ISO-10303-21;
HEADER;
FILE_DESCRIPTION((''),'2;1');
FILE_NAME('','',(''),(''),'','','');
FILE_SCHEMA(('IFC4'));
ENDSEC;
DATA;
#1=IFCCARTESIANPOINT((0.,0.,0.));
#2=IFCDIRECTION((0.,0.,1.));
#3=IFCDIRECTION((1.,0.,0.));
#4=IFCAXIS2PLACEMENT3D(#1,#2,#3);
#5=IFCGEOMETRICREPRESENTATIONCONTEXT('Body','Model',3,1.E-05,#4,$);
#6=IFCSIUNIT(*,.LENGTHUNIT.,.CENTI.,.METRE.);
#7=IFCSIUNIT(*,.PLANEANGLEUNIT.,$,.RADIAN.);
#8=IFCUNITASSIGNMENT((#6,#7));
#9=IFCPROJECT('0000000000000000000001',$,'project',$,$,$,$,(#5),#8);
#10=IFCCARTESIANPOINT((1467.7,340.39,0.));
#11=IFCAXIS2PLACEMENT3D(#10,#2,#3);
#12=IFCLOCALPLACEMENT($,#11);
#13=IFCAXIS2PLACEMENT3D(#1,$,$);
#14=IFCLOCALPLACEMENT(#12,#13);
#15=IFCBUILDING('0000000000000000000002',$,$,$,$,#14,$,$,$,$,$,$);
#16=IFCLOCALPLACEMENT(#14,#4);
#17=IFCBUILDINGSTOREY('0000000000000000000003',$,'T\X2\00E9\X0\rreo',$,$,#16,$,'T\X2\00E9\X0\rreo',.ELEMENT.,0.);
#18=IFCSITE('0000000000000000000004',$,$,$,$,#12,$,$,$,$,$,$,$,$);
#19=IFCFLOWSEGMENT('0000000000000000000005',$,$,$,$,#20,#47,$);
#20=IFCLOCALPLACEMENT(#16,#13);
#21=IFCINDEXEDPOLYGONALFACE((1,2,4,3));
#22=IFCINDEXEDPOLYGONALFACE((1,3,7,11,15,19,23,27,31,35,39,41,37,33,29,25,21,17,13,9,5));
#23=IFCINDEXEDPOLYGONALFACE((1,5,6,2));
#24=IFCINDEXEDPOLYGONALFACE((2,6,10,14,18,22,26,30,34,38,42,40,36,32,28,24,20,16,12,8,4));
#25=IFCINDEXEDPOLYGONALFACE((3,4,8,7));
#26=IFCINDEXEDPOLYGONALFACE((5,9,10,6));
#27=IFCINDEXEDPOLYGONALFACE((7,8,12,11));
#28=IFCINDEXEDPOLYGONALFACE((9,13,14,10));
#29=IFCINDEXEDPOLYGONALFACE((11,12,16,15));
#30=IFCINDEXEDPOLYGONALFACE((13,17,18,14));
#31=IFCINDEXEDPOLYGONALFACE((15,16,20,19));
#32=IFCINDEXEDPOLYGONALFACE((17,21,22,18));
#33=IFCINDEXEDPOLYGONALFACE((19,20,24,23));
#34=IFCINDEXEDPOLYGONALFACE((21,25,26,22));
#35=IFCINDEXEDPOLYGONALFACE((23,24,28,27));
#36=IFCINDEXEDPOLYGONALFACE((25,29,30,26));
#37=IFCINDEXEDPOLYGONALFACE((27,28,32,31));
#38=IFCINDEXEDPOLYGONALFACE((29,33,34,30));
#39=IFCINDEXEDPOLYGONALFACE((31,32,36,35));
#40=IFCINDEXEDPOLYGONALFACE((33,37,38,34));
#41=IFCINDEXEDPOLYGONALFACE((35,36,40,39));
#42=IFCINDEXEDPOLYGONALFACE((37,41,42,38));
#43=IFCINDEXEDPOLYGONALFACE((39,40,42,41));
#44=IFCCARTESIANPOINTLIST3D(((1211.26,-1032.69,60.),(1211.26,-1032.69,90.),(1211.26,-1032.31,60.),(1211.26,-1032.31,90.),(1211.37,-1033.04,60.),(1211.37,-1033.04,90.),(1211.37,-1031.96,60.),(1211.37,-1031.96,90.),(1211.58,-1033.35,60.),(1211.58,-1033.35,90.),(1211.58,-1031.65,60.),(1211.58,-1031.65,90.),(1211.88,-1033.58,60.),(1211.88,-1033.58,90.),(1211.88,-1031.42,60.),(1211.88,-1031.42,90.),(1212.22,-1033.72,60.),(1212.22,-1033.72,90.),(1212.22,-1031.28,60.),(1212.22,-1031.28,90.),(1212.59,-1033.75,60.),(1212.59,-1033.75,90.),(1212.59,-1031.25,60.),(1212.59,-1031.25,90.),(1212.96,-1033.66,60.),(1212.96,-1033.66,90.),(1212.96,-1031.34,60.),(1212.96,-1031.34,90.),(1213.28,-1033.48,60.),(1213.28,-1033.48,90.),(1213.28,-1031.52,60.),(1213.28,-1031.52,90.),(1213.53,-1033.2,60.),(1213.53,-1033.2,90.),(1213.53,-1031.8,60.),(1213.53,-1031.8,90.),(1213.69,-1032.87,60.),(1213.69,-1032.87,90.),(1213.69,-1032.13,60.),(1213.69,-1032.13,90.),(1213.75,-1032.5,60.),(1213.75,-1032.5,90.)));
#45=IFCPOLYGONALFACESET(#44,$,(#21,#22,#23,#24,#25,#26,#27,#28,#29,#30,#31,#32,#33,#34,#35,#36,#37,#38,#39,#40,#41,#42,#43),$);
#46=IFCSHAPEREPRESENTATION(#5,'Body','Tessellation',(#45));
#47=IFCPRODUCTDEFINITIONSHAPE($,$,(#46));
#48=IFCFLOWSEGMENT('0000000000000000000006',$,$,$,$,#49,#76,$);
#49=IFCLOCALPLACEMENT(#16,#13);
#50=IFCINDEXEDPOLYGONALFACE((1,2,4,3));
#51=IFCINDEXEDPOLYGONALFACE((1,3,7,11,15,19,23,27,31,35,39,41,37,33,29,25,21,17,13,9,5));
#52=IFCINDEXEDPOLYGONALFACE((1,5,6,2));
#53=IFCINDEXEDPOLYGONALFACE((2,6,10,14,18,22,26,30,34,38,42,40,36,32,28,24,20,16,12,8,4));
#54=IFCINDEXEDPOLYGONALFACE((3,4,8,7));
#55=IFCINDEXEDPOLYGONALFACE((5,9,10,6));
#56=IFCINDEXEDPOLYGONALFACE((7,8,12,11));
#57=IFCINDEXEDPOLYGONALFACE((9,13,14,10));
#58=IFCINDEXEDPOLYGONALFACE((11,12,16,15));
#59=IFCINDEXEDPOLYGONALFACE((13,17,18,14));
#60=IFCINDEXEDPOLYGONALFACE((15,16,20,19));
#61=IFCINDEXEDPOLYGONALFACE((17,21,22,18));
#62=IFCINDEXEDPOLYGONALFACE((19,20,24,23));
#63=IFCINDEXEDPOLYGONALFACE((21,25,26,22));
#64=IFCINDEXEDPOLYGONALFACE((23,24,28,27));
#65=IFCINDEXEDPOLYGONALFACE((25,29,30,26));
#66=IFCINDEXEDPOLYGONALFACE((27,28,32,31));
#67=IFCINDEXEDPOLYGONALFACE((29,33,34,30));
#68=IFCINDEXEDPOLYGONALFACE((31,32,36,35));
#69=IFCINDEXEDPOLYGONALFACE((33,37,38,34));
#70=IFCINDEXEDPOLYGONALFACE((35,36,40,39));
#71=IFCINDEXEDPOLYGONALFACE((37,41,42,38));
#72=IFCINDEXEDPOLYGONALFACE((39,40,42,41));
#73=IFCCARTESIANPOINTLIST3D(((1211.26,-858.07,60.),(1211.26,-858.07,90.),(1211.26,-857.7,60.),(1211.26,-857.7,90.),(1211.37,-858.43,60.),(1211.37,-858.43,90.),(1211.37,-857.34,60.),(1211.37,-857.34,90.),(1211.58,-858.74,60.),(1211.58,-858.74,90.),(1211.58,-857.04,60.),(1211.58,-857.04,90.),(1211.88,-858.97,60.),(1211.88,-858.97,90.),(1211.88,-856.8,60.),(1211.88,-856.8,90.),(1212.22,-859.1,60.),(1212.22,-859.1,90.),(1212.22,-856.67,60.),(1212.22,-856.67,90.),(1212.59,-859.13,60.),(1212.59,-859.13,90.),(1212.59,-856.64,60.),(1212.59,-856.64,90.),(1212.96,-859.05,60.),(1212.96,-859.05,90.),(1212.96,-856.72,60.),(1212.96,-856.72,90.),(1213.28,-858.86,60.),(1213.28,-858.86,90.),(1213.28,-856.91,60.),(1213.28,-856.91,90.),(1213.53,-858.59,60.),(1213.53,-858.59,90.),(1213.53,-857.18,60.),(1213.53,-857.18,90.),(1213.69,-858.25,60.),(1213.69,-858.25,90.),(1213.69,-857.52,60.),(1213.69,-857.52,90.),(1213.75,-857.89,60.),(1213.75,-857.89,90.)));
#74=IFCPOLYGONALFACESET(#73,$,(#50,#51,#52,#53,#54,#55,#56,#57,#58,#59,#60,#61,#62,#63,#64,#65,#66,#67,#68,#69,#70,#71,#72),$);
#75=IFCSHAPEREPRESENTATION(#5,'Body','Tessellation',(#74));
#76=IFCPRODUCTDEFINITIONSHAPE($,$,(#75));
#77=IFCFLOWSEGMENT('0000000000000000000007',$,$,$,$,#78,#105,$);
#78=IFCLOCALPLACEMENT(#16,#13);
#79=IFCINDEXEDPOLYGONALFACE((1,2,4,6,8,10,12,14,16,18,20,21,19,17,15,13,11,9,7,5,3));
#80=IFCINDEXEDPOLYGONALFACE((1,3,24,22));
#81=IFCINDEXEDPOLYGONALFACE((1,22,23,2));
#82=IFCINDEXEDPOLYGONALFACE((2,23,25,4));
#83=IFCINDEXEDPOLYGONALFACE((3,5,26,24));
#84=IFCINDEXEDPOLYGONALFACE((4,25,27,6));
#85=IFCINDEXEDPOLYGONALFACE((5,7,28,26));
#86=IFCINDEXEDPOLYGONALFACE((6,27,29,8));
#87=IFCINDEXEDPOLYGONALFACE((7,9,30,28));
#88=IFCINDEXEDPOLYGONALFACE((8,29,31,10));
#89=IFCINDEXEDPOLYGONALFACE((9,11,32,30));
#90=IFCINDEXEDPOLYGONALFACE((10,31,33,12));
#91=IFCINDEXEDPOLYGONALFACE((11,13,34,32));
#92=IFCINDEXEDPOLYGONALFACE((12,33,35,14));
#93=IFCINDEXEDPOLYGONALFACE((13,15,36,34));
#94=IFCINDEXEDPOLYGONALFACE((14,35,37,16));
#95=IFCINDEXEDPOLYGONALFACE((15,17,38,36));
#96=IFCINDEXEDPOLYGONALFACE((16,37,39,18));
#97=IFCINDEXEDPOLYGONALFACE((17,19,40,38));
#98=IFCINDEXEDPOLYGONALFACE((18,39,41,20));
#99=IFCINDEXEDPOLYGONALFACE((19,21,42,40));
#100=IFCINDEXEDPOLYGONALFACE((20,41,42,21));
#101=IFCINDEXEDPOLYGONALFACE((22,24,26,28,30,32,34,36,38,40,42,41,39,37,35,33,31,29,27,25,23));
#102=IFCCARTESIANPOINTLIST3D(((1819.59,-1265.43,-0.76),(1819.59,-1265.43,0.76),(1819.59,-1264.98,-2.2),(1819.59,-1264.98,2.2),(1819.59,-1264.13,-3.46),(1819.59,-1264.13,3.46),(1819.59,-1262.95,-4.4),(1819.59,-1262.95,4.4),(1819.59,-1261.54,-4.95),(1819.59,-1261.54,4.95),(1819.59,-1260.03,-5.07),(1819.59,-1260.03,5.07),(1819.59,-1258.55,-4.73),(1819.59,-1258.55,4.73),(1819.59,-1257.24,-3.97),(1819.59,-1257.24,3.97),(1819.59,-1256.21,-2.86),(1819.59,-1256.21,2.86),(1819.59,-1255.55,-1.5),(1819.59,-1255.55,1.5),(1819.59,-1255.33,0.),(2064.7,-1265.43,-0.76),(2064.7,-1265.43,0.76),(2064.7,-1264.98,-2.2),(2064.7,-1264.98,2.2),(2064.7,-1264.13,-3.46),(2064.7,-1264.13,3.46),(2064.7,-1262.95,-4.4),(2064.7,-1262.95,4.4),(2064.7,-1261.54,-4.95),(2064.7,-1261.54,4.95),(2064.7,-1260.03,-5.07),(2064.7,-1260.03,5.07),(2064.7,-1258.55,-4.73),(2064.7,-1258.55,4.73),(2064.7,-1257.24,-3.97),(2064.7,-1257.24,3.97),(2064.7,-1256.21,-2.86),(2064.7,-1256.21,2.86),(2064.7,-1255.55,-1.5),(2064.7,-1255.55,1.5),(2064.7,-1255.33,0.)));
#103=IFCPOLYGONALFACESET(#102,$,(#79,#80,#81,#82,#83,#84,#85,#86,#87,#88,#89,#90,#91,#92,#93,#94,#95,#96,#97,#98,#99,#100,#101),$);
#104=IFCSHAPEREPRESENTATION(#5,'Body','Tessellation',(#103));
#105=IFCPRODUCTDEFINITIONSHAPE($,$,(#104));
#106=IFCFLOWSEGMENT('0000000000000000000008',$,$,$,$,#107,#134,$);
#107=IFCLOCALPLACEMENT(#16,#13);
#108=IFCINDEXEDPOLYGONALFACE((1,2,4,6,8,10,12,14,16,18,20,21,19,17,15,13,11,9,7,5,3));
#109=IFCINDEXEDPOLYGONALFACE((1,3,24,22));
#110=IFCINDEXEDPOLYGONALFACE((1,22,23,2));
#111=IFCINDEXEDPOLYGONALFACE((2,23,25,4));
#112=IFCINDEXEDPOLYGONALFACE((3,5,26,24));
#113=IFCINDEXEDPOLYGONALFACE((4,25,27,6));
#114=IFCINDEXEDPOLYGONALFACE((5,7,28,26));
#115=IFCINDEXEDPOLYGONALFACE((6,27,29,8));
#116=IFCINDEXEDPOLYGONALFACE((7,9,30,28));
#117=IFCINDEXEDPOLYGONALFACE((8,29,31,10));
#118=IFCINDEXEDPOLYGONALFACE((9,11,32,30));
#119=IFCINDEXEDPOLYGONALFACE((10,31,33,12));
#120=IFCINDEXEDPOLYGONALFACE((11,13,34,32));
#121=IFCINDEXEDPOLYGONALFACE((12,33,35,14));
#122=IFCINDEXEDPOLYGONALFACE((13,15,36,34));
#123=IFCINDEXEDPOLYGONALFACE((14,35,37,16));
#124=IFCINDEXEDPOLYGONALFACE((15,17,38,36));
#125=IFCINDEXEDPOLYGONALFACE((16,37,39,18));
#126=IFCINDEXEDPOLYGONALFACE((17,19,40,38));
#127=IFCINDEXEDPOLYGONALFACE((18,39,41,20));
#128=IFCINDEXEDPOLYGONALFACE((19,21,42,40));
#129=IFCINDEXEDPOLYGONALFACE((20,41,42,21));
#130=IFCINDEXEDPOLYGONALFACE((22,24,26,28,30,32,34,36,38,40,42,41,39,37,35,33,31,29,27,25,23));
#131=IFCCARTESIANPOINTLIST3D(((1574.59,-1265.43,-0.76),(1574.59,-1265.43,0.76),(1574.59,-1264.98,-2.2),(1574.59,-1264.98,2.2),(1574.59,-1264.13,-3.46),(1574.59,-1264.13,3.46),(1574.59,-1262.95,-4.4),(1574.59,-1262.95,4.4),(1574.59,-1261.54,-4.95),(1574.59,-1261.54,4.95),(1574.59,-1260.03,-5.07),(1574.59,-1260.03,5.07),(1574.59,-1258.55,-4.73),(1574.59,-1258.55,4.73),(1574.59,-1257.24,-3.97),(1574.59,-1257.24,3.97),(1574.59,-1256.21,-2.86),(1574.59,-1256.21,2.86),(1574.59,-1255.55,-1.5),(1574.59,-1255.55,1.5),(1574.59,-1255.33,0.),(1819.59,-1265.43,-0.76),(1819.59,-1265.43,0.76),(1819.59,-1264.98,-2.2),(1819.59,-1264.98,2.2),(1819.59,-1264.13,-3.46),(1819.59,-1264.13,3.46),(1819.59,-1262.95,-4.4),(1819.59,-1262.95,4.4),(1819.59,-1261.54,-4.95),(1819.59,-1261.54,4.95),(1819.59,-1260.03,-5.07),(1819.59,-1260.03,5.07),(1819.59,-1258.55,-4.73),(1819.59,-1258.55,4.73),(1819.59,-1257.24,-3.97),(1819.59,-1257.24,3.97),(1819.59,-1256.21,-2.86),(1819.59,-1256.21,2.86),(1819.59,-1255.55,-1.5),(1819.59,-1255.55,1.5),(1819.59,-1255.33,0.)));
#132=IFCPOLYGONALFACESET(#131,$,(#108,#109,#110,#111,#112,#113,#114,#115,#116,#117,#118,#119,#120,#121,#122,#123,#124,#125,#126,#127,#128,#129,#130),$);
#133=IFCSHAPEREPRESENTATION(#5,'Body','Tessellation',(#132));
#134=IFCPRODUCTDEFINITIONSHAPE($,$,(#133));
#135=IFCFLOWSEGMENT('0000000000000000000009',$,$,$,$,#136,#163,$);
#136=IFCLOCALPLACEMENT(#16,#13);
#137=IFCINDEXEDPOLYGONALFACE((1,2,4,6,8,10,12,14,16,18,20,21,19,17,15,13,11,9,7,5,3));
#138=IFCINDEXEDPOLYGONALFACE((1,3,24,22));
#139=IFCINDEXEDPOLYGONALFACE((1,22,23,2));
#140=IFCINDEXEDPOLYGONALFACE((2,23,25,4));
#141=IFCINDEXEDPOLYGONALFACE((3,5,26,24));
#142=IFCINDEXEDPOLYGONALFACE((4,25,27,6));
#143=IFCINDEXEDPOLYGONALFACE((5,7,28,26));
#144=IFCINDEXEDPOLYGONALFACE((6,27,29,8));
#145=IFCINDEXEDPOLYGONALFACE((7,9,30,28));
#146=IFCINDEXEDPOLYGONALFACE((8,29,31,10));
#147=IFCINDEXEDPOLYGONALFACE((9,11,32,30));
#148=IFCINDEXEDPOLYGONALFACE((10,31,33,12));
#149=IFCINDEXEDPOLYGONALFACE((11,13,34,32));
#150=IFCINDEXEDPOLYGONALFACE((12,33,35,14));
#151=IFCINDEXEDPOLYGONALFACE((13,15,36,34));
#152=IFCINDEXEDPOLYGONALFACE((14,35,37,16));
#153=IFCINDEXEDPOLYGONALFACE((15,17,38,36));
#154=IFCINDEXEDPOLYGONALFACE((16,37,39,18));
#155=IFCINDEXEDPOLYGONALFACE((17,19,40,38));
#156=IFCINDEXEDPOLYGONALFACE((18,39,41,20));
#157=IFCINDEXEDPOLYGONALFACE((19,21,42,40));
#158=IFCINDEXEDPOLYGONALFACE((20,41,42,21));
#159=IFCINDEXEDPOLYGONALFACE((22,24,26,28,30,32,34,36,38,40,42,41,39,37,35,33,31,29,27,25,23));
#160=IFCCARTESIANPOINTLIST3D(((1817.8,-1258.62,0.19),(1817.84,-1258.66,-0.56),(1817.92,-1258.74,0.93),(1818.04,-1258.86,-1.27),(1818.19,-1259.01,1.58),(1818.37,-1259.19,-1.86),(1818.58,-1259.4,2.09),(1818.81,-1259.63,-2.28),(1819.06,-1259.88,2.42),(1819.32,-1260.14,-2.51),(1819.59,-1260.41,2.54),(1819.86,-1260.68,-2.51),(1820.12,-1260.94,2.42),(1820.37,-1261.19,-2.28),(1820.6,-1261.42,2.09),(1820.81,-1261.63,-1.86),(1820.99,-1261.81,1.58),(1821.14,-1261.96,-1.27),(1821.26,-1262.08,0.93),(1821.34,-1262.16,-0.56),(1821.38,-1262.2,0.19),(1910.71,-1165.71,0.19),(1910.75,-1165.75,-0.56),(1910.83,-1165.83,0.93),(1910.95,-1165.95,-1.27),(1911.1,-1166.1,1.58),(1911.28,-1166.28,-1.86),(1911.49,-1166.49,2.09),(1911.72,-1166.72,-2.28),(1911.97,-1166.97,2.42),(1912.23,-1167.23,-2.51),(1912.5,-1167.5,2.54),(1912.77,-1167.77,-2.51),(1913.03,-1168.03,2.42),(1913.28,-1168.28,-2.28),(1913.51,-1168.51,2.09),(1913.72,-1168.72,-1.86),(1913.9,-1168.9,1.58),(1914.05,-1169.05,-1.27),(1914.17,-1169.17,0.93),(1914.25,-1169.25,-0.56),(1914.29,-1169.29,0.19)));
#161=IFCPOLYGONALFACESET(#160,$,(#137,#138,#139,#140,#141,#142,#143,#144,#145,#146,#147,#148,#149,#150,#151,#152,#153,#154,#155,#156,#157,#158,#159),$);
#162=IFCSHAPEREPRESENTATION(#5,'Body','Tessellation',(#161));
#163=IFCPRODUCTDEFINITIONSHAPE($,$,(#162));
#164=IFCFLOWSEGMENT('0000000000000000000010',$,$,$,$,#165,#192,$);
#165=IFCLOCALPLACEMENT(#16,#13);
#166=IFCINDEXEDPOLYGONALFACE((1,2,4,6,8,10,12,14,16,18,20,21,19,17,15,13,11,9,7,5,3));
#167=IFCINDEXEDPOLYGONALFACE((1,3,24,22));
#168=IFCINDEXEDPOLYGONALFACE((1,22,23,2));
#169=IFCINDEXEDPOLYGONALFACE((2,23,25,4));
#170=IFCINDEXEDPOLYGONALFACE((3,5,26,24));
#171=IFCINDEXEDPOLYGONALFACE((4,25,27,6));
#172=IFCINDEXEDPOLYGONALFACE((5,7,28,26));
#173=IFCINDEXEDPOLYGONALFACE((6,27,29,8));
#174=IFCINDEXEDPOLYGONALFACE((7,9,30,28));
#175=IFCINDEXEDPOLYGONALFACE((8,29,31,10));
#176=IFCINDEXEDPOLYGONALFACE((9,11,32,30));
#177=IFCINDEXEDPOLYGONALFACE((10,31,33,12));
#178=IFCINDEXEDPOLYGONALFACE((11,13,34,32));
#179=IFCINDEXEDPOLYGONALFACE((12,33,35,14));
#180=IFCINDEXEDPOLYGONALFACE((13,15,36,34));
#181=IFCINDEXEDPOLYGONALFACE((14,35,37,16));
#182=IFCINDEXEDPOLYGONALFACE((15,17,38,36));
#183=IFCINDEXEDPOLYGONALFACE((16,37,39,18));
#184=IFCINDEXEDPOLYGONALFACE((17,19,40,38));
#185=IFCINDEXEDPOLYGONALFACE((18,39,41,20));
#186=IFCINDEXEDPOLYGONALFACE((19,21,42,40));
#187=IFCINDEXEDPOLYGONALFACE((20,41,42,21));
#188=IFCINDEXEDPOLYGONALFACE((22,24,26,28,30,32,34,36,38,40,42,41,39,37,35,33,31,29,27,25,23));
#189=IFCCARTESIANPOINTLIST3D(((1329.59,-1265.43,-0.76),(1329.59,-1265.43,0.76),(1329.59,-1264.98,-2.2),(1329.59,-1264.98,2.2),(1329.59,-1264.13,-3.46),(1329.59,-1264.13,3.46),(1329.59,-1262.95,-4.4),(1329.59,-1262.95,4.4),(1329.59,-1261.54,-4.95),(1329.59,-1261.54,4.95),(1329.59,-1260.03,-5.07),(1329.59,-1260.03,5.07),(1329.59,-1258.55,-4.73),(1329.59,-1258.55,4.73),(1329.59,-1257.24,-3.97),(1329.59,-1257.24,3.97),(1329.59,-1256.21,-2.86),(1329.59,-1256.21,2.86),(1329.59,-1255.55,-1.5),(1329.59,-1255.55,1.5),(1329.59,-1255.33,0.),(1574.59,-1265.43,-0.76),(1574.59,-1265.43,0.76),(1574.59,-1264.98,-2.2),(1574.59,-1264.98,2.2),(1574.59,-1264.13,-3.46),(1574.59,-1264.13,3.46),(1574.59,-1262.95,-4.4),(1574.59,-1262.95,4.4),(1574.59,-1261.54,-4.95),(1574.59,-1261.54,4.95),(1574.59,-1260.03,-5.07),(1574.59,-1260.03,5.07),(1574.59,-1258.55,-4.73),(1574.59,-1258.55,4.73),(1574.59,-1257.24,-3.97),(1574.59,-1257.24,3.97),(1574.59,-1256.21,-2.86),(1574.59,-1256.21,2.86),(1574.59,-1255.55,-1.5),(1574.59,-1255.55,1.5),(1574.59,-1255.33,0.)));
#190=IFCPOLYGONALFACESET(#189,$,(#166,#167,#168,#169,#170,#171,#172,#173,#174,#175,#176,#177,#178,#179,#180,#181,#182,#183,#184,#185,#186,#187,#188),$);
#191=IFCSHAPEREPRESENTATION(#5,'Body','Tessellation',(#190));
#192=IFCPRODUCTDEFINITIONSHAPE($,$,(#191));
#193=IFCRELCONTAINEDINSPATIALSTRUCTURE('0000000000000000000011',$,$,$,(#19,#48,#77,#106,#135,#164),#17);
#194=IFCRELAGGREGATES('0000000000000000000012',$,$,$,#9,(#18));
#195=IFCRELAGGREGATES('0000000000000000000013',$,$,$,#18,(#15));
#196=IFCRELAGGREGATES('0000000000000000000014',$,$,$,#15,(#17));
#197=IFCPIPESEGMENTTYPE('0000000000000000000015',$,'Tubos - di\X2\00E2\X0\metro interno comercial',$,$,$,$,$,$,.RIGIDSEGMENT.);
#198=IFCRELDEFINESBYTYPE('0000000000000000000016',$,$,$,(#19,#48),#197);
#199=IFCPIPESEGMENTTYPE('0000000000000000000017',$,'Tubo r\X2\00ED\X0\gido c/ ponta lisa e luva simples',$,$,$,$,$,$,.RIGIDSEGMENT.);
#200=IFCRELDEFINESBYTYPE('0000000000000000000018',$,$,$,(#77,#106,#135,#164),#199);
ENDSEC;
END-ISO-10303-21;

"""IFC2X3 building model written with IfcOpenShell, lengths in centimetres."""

from ifc_helpers import new_model, si_unit, frame, origin, origin_with_axes, origin_2d_with_axis, place, context, project, spatial, circle, extrude, type_object, element, save


model = new_model("IFC2X3")

# Units and contexts
model_context = context("Model", 3, precision=1e-05, world=origin_with_axes(), identifier="Body")
ifc_project = project(units=[si_unit("LENGTHUNIT", "METRE", prefix="CENTI"), si_unit("PLANEANGLEUNIT", "RADIAN")], contexts=[model_context])

# Site, building, storey
site_placement = place(None, frame((1467.7, 340.39, 0.0), z_axis=(0.0, 0.0, 1.0), x_axis=(1.0, 0.0, 0.0)))
site = spatial("IfcSite", under=ifc_project, at=site_placement)
building_placement = place(site_placement, origin())
building = spatial("IfcBuilding", under=site, at=building_placement)
storey_placement = place(building_placement, origin_with_axes())
storey = spatial("IfcBuildingStorey", under=building, at=storey_placement, Name="Térreo", LongName="Térreo", CompositionType="ELEMENT", Elevation=0.0)

# Flow segments
pipe_segment_type_1 = type_object("IfcPipeSegmentType", Name="Tubos - diâmetro interno comercial", PredefinedType="RIGIDSEGMENT")
for number, where, z_axis, x_axis in (
    (1, (1212.5, -1032.5, 90.0), (0.0, 0.0, 1.0), (1.0, 0.0, 0.0)),
    (2, (1212.5, -857.89, 90.0), (0.0, 0.0, 1.0), (1.0, 0.0, 0.0)),
):
    element("IfcFlowSegment", number, at=place(storey_placement, frame(where, z_axis=z_axis, x_axis=x_axis)), inside=storey, type_object=pipe_segment_type_1, context=model_context, shape_type="SolidModel", body=[
        extrude(circle(Radius=1.25, at=origin_2d_with_axis()), frame((0.0, 0.0, 0.0), z_axis=(0.0, 0.0, -1.0), x_axis=(1.0, 0.0, 0.0)), (0.0, 0.0, 1.0), 30.0),
    ])
pipe_segment_type_2 = type_object("IfcPipeSegmentType", Name="Tubo rígido c/ ponta lisa e luva simples", PredefinedType="RIGIDSEGMENT")
flow_segment_1_placement = place(storey_placement, frame((1942.14, -1260.41, 5.08), z_axis=(0.0, 0.0, 1.0), x_axis=(1.0, 0.0, 0.0)))
element("IfcFlowSegment", 3, at=flow_segment_1_placement, inside=storey, type_object=pipe_segment_type_2, context=model_context, shape_type="SolidModel", body=[
    extrude(circle(Radius=5.08, at=origin_2d_with_axis()), frame((122.55, 0.0, -5.08), z_axis=(-1.0, 0.0, 0.0), x_axis=(0.0, 1.0, 0.0)), (0.0, 0.0, 1.0), 245.1),
])
flow_segment_2_placement = place(storey_placement, frame((1697.09, -1260.41, 5.08), z_axis=(0.0, 0.0, 1.0), x_axis=(1.0, 0.0, 0.0)))
element("IfcFlowSegment", 4, at=flow_segment_2_placement, inside=storey, type_object=pipe_segment_type_2, context=model_context, shape_type="SolidModel", body=[
    extrude(circle(Radius=5.08, at=origin_2d_with_axis()), frame((122.5, 0.0, -5.08), z_axis=(-1.0, 0.0, 0.0), x_axis=(0.0, 1.0, 0.0)), (0.0, 0.0, 1.0), 245.0),
])
flow_segment_3_placement = place(storey_placement, frame((1866.05, -1213.95, 2.54), z_axis=(0.0, 0.0, 1.0), x_axis=(1.0, 0.0, 0.0)))
element("IfcFlowSegment", 5, at=flow_segment_3_placement, inside=storey, type_object=pipe_segment_type_2, context=model_context, shape_type="SolidModel", body=[
    extrude(circle(Radius=2.54, at=origin_2d_with_axis()), frame((46.45, 46.45, -2.54), z_axis=(-0.707107, -0.707107, 0.0), x_axis=(0.0, 0.0, 1.0)), (0.0, 0.0, 1.0), 131.39),
])
flow_segment_4_placement = place(storey_placement, frame((1452.09, -1260.41, 5.08), z_axis=(0.0, 0.0, 1.0), x_axis=(1.0, 0.0, 0.0)))
element("IfcFlowSegment", 6, at=flow_segment_4_placement, inside=storey, type_object=pipe_segment_type_2, context=model_context, shape_type="SolidModel", body=[
    extrude(circle(Radius=5.08, at=origin_2d_with_axis()), frame((122.5, 0.0, -5.08), z_axis=(-1.0, 0.0, 0.0), x_axis=(0.0, 1.0, 0.0)), (0.0, 0.0, 1.0), 245.0),
])

save(model, "model.ifc")
